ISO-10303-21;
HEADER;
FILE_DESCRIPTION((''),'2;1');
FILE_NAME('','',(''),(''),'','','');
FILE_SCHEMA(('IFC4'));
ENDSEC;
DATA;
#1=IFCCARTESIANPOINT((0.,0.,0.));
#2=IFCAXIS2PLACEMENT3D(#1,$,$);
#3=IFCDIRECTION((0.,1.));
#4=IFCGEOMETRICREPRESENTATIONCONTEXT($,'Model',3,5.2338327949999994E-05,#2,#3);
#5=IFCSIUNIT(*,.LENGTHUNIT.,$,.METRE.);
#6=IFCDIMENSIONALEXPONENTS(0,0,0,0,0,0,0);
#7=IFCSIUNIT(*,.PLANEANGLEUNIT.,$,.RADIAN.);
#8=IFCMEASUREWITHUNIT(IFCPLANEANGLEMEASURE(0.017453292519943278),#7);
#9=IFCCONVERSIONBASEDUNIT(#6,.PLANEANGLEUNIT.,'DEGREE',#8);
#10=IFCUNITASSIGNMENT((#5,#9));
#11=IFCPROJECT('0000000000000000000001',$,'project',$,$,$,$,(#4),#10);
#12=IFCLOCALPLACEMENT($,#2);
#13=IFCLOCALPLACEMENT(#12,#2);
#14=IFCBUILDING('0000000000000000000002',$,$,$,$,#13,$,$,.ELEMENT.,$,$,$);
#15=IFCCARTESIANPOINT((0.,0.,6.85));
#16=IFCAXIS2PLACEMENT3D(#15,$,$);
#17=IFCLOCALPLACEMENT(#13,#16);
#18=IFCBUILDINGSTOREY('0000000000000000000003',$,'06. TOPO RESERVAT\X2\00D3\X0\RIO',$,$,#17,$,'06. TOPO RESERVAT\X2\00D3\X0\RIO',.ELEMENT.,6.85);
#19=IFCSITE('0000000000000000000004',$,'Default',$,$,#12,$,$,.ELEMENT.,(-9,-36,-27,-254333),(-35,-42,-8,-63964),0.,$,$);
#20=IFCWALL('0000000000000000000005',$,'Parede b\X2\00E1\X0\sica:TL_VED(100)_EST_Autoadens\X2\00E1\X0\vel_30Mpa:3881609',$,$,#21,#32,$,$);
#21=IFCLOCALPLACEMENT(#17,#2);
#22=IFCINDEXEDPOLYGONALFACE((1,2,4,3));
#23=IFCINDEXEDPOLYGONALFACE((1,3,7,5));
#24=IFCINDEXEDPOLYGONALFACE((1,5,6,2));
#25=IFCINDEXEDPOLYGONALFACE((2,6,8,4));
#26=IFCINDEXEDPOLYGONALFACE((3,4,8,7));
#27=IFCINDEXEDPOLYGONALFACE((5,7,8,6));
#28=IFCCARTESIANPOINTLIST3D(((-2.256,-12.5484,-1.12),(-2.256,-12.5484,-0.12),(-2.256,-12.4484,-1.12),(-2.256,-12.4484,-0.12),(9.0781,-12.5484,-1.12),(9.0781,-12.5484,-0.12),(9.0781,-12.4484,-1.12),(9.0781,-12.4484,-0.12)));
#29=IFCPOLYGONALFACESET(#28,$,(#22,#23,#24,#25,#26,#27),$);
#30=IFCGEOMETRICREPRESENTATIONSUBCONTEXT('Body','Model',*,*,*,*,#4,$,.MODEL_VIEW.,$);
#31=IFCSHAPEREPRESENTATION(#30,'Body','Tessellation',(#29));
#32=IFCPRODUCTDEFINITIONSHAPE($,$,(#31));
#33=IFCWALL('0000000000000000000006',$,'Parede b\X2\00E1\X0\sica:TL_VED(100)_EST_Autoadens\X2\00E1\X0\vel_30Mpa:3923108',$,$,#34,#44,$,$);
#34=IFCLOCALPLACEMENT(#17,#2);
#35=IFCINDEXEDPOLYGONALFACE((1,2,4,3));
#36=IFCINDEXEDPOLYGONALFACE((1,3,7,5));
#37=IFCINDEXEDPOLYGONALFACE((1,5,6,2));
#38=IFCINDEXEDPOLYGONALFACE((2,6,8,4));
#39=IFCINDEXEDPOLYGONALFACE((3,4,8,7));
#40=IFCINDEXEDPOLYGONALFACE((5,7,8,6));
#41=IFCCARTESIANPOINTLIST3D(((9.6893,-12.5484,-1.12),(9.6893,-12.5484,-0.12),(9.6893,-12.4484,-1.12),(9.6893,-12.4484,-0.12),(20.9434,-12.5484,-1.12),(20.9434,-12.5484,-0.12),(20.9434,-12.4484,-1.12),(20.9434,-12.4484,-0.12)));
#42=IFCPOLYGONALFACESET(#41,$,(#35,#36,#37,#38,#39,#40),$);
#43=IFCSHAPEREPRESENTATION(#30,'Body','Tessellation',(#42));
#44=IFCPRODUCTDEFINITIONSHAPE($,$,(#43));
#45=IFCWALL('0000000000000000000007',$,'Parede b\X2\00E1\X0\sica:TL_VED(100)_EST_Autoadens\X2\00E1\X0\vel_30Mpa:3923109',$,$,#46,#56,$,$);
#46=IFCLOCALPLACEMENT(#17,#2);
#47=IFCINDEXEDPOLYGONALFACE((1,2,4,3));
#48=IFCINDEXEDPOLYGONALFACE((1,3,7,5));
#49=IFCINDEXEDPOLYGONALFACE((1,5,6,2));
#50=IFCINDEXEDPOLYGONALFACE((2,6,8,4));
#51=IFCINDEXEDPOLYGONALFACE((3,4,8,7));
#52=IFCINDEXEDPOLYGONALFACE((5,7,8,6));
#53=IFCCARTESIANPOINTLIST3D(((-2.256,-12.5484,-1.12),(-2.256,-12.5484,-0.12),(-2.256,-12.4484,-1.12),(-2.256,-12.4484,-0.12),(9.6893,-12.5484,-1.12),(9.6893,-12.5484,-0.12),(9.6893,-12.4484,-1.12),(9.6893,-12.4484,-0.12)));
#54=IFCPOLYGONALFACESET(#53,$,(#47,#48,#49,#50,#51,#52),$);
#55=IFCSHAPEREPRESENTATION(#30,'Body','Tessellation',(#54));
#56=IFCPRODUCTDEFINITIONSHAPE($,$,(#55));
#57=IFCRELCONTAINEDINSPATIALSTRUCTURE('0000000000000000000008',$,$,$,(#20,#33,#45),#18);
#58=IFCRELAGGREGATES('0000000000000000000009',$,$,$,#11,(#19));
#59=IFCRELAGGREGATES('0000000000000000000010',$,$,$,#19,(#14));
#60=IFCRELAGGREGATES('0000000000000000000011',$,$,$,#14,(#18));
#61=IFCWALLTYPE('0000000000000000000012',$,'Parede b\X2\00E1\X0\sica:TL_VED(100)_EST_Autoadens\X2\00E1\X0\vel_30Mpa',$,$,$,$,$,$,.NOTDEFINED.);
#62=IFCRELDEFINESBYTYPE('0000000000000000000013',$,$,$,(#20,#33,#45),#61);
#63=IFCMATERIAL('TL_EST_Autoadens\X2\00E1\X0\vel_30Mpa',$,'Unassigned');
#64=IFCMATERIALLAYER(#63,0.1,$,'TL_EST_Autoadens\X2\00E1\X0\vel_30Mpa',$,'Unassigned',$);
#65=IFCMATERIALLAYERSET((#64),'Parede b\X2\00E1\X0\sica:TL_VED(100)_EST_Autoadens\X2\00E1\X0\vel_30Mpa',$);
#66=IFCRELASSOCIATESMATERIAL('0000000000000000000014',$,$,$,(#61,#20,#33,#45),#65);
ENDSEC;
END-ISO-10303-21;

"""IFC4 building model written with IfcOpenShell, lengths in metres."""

from ifc_helpers import new_model, entity, si_unit, converted_unit, direction, frame, frame_2d, origin, place, context, subcontext, project, spatial, rectangle, extrude, material, layer, layer_set, layer_usage, type_object, element, save


model = new_model("IFC4")

# Units and contexts
model_context = context("Model", 3, precision=5.2338327949999994e-05, world=origin(), true_north=direction((0.0, 1.0)))
body_context = subcontext(model_context, "Body", "Model", "MODEL_VIEW")
ifc_project = project(units=[si_unit("LENGTHUNIT", "METRE"), converted_unit("PLANEANGLEUNIT", "DEGREE", entity("IfcPlaneAngleMeasure", 0.017453292519943278), si_unit("PLANEANGLEUNIT", "RADIAN"), dimensions=[0, 0, 0, 0, 0, 0, 0])], contexts=[model_context])

# Site, building, storey
site_placement = place(None, frame((0.0, 0.0, 0.0)))
site = spatial("IfcSite", under=ifc_project, at=site_placement, Name="Default", CompositionType="ELEMENT", RefLatitude=(-9, -36, -27, -254333), RefLongitude=(-35, -42, -8, -63964), RefElevation=0.0)
building_placement = place(site_placement, origin())
building = spatial("IfcBuilding", under=site, at=building_placement, CompositionType="ELEMENT")
storey_placement = place(building_placement, frame((0.0, 0.0, 6.85)))
storey = spatial("IfcBuildingStorey", under=building, at=storey_placement, Name="06. TOPO RESERVATÓRIO", LongName="06. TOPO RESERVATÓRIO", CompositionType="ELEMENT", Elevation=6.85)

# Walls
ifc_material_1 = material(Name="TL_EST_Autoadensável_30Mpa", Category="Unassigned")
ifc_layer = layer(ifc_material_1, 0.1, Name="TL_EST_Autoadensável_30Mpa", Category="Unassigned")
ifc_layer_set = layer_set([ifc_layer], Name="Parede básica:TL_VED(100)_EST_Autoadensável_30Mpa")
ifc_layer_usage_1 = layer_usage(ifc_layer_set, "AXIS2", "NEGATIVE", 0.05)
wall_type = type_object("IfcWallType", Name="Parede básica:TL_VED(100)_EST_Autoadensável_30Mpa", PredefinedType="NOTDEFINED", material=ifc_layer_set)
wall_1_placement = place(storey_placement, frame((9.0781, -12.4984, -1.12), z_axis=(0.0, 0.0, 1.0), x_axis=(-1.0, 0.0, 0.0)))
element("IfcWall", 1, at=wall_1_placement, inside=storey, type_object=wall_type, material=ifc_layer_usage_1, Name="Parede básica:TL_VED(100)_EST_Autoadensável_30Mpa:3881609", context=body_context, shape_type="SweptSolid", body=[
    extrude(rectangle(XDim=11.3341, YDim=0.1, at=frame_2d((5.6671, 0.0), x_axis=(-1.0, 0.0))), origin(), (0.0, 0.0, 1.0), 1.0),
])
ifc_layer_usage_2 = layer_usage(ifc_layer_set, "AXIS2", "POSITIVE", -0.05)
wall_2_placement = place(storey_placement, frame((9.6893, -12.4984, -1.12)))
element("IfcWall", 2, at=wall_2_placement, inside=storey, type_object=wall_type, material=ifc_layer_usage_2, Name="Parede básica:TL_VED(100)_EST_Autoadensável_30Mpa:3923108", context=body_context, shape_type="SweptSolid", body=[
    extrude(rectangle(XDim=11.2541, YDim=0.1, at=frame_2d((5.6271, 0.0), x_axis=(-1.0, 0.0))), origin(), (0.0, 0.0, 1.0), 1.0),
])
ifc_layer_usage_3 = layer_usage(ifc_layer_set, "AXIS2", "NEGATIVE", 0.05)
wall_3_placement = place(storey_placement, frame((9.6893, -12.4984, -1.12), z_axis=(0.0, 0.0, 1.0), x_axis=(-1.0, 0.0, 0.0)))
element("IfcWall", 3, at=wall_3_placement, inside=storey, type_object=wall_type, material=ifc_layer_usage_3, Name="Parede básica:TL_VED(100)_EST_Autoadensável_30Mpa:3923109", context=body_context, shape_type="SweptSolid", body=[
    extrude(rectangle(XDim=11.9453, YDim=0.1, at=frame_2d((5.9726, 0.0), x_axis=(-1.0, 0.0))), origin(), (0.0, 0.0, 1.0), 1.0),
])

save(model, "model.ifc")
